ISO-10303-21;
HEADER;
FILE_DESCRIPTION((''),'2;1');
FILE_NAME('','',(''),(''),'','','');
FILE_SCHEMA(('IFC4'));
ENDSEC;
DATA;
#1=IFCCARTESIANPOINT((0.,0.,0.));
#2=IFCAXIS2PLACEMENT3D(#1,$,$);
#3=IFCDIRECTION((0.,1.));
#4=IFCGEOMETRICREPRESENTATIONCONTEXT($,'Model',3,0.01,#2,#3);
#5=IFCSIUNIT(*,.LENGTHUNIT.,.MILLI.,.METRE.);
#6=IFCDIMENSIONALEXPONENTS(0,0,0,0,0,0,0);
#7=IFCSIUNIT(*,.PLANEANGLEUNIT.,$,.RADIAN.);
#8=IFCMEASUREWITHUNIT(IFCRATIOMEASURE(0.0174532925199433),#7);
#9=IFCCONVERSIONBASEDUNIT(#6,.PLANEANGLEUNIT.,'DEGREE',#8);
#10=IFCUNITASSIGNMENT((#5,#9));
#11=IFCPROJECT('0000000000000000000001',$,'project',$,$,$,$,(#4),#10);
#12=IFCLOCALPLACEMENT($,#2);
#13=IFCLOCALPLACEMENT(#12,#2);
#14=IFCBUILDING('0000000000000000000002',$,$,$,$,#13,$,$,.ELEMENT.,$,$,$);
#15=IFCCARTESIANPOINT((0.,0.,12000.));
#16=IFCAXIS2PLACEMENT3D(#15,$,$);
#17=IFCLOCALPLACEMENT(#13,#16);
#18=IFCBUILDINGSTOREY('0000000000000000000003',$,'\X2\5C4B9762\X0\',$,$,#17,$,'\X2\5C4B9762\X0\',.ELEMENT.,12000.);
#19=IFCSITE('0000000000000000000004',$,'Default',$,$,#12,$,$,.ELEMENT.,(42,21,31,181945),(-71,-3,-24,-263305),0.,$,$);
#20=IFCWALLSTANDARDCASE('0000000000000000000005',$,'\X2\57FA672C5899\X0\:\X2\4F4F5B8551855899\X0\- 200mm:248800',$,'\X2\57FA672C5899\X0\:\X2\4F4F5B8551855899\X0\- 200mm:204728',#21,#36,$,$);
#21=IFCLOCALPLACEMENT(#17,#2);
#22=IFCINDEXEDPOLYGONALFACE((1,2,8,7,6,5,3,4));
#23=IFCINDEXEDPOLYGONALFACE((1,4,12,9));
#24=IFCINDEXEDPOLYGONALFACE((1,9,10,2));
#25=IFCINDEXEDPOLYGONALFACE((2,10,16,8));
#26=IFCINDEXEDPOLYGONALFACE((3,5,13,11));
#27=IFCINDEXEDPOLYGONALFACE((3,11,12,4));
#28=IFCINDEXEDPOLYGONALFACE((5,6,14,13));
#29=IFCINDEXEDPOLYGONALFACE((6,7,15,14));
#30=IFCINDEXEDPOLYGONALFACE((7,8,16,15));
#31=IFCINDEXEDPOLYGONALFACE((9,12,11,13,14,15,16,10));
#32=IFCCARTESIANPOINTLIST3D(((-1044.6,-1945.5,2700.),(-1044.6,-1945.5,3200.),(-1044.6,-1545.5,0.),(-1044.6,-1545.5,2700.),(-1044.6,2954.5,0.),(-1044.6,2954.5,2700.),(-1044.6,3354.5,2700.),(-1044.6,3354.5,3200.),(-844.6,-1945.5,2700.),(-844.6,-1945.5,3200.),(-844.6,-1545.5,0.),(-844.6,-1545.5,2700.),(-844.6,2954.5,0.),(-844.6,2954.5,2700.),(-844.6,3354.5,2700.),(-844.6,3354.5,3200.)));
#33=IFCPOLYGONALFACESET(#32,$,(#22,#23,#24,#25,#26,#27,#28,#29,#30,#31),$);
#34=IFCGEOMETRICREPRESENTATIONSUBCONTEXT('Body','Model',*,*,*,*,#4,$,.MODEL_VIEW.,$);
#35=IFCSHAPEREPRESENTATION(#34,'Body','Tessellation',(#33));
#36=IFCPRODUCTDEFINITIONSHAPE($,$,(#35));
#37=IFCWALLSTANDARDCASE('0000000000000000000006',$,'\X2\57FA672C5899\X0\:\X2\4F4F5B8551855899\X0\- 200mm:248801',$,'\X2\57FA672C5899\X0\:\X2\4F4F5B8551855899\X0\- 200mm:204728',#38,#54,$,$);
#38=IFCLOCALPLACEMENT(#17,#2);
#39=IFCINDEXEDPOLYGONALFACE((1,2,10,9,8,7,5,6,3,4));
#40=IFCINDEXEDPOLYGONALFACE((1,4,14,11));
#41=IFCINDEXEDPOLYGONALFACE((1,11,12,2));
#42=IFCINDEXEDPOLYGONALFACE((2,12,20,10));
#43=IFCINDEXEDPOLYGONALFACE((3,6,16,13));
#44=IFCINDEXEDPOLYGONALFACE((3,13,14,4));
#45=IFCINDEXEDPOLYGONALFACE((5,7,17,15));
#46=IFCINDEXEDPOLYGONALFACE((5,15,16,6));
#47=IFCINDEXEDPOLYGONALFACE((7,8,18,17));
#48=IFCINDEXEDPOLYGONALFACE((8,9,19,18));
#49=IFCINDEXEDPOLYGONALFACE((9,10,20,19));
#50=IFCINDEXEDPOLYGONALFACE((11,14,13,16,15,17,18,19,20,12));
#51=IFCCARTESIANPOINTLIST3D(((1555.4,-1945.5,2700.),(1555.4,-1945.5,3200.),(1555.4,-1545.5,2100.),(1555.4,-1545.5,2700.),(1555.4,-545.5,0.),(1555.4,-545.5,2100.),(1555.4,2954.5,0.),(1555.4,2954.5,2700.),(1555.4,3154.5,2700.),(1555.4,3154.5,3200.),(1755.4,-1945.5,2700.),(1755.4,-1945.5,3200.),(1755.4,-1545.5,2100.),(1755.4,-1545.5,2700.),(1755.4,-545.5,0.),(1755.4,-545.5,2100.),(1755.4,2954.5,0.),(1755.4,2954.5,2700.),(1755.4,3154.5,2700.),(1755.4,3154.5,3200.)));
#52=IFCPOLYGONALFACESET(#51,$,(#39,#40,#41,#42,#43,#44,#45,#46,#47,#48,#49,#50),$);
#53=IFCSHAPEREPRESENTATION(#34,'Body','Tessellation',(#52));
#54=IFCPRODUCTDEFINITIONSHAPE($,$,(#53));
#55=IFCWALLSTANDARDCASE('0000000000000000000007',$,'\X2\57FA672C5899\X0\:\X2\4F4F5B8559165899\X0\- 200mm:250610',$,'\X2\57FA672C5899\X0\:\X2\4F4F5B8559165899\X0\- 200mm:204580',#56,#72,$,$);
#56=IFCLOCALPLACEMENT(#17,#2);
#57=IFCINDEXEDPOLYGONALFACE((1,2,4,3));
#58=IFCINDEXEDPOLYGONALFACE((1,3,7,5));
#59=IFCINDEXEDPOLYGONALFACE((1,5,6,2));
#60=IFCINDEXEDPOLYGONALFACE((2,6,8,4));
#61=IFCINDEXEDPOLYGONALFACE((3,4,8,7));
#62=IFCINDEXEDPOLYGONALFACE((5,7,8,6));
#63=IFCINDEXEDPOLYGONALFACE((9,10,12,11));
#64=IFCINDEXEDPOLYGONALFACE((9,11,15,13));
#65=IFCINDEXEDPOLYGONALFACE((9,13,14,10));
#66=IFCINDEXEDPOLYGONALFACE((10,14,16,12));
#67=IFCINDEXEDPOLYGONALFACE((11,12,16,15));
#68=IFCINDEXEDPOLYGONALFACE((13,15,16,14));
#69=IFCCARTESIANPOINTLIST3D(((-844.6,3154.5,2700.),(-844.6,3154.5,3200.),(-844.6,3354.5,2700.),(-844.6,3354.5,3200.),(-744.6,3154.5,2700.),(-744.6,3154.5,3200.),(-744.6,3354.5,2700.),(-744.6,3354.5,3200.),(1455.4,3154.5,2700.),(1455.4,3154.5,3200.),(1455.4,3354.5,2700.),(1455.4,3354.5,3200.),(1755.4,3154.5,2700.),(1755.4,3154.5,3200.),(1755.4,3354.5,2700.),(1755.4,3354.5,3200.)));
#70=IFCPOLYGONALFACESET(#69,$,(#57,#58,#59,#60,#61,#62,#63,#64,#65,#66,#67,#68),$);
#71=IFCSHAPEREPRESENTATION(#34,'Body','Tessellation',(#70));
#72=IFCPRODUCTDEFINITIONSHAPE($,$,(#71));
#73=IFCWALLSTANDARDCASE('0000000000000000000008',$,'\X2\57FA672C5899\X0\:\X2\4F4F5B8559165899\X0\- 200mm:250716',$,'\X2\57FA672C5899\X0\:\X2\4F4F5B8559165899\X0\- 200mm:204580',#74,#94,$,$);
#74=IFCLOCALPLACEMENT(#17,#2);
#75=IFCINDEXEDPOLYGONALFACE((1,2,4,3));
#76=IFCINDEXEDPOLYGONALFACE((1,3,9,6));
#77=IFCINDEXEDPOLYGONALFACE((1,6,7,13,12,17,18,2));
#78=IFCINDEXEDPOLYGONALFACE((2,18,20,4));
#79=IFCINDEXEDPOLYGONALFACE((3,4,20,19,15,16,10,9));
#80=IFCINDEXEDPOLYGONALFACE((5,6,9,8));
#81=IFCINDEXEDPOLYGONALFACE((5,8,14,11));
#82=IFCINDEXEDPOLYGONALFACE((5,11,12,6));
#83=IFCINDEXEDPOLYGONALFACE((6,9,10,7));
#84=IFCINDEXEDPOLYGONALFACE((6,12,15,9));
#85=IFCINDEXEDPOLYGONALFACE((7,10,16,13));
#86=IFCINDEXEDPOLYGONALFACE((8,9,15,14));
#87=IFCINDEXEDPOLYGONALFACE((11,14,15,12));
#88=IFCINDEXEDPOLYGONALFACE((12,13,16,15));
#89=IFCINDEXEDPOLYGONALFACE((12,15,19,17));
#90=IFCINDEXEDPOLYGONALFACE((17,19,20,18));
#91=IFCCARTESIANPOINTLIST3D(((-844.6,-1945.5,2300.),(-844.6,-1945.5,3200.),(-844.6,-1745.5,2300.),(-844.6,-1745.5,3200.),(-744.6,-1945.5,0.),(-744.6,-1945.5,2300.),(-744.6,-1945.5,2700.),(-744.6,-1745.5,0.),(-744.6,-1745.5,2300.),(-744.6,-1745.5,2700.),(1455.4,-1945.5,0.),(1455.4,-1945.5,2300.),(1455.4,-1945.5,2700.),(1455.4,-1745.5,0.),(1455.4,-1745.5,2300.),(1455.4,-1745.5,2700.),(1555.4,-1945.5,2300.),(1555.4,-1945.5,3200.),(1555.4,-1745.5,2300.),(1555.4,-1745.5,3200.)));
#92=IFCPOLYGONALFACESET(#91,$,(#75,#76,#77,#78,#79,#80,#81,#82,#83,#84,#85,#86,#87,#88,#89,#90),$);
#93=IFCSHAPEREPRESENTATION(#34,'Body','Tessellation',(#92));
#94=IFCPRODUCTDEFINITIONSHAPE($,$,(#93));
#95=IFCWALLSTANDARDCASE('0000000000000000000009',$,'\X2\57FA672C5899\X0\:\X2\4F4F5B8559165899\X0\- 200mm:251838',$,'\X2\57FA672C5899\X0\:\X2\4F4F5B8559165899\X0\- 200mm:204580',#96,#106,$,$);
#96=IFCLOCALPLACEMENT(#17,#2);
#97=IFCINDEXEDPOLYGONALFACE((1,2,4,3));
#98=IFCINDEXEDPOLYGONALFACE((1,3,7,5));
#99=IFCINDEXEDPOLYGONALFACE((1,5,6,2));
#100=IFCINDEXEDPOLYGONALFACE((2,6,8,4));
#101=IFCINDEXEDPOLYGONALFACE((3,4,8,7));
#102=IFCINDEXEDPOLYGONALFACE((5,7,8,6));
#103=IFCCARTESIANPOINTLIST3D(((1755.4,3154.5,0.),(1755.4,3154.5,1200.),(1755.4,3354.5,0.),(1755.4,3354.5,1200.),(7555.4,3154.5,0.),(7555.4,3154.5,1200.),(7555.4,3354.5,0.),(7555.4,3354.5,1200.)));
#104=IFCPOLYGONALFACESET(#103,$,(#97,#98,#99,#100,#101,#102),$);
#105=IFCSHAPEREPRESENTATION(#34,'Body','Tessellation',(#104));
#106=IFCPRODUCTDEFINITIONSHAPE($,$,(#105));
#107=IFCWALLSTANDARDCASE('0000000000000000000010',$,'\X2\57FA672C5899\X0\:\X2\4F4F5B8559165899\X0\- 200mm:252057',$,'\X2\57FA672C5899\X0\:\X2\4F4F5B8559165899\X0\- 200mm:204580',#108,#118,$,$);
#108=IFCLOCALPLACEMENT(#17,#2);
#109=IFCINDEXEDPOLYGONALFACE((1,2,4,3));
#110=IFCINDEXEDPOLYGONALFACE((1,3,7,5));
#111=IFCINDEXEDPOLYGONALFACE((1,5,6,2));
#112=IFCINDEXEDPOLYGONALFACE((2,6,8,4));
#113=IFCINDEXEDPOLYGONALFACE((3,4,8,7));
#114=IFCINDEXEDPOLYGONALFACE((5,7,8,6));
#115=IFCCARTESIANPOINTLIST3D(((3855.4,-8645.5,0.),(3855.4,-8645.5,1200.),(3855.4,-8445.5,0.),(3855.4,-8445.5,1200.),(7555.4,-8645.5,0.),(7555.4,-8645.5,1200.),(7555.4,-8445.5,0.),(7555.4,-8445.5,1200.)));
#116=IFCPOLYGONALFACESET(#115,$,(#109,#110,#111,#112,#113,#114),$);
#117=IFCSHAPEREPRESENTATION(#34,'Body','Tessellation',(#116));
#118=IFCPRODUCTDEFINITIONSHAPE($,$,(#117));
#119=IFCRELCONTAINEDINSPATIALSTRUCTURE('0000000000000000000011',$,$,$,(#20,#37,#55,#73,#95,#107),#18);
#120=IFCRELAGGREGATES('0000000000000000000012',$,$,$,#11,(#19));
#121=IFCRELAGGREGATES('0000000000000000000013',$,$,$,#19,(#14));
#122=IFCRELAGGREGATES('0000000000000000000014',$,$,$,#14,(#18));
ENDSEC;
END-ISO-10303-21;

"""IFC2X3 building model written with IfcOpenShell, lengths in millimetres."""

from ifc_helpers import new_model, entity, si_unit, converted_unit, direction, frame, frame_2d, origin, origin_2d_with_axis, place, context, subcontext, project, spatial, polyline, rectangle, extrude, clip, bounded_halfspace, element, save


model = new_model("IFC2X3")

# Units and contexts
model_context = context("Model", 3, precision=0.01, world=origin(), true_north=direction((0.0, 1.0)))
body_context = subcontext(model_context, "Body", "Model", "MODEL_VIEW")
ifc_project = project(units=[si_unit("LENGTHUNIT", "METRE", prefix="MILLI"), converted_unit("PLANEANGLEUNIT", "DEGREE", entity("IfcRatioMeasure", 0.0174532925199433), si_unit("PLANEANGLEUNIT", "RADIAN"), dimensions=[0, 0, 0, 0, 0, 0, 0])], contexts=[model_context])

# Site, building, storey
site_placement = place(None, origin())
site = spatial("IfcSite", under=ifc_project, at=site_placement, Name="Default", CompositionType="ELEMENT", RefLatitude=(42, 21, 31, 181945), RefLongitude=(-71, -3, -24, -263305), RefElevation=0.0)
building_placement = place(site_placement, origin())
building = spatial("IfcBuilding", under=site, at=building_placement, CompositionType="ELEMENT")
storey_placement = place(building_placement, frame((0.0, 0.0, 12000.0)))
storey = spatial("IfcBuildingStorey", under=building, at=storey_placement, Name="屋面", LongName="屋面", CompositionType="ELEMENT", Elevation=12000.0)

# Wall
wall_1_placement = place(storey_placement, frame((-944.6, 3354.5, 0.0), z_axis=(0.0, 0.0, 1.0), x_axis=(0.0, -1.0, 0.0)))
element("IfcWallStandardCase", 1, at=wall_1_placement, inside=storey, Name="基本墙:住宅内墙- 200mm:248800", ObjectType="基本墙:住宅内墙- 200mm:204728", context=body_context, shape_type="Clipping", body=[
    clip(clip(clip(clip(extrude(rectangle(XDim=5300.0, YDim=200.0, at=frame_2d((2650.0, 0.0), x_axis=(-1.0, 0.0))), origin(), (0.0, 0.0, 1.0), 3200.0), bounded_halfspace(frame((400.0, -100.0, 2700.0), z_axis=(1.0, 0.0, 0.0), x_axis=(0.0, 0.0, -1.0)), True, frame((400.0, -100.0, 2700.0), z_axis=(1.0, 0.0, 0.0), x_axis=(0.0, 0.0, -1.0)), polyline([(0.0, 0.0), (2700.0, 0.0), (2700.0, 200.0), (0.0, 200.0), (0.0, 0.0)]))), bounded_halfspace(frame((400.0, 100.0, 2700.0), z_axis=(0.0, 0.0, 1.0), x_axis=(0.0, -1.0, 0.0)), True, frame((400.0, 100.0, 2700.0), z_axis=(0.0, 0.0, 1.0), x_axis=(0.0, -1.0, 0.0)), polyline([(0.0, 0.0), (0.0, -200.0), (0.0, -400.0), (200.0, -400.0), (200.0, 0.0), (0.0, 0.0)]))), bounded_halfspace(frame((4900.0, 100.0, 2700.0), z_axis=(1.0, 0.0, 0.0), x_axis=(0.0, 0.0, -1.0)), False, frame((4900.0, 100.0, 2700.0), z_axis=(1.0, 0.0, 0.0), x_axis=(0.0, 0.0, -1.0)), polyline([(0.0, 0.0), (0.0, -200.0), (2700.0, -200.0), (2700.0, 0.0), (0.0, 0.0)]))), bounded_halfspace(frame((4900.0, -100.0, 2700.0), z_axis=(0.0, 0.0, -1.0), x_axis=(0.0, 1.0, 0.0)), False, frame((4900.0, -100.0, 2700.0), z_axis=(0.0, 0.0, -1.0), x_axis=(0.0, 1.0, 0.0)), polyline([(0.0, 0.0), (200.0, 0.0), (200.0, 200.0), (200.0, 400.0), (0.0, 400.0), (0.0, 0.0)]))),
])

# Walls, openings
wall_2_placement = place(storey_placement, frame((1655.4, -1945.5, 0.0), z_axis=(0.0, 0.0, 1.0), x_axis=(0.0, 1.0, 0.0)))
wall_2 = element("IfcWallStandardCase", 2, at=wall_2_placement, inside=storey, Name="基本墙:住宅内墙- 200mm:248801", ObjectType="基本墙:住宅内墙- 200mm:204728", context=body_context, shape_type="Clipping", body=[
    clip(clip(clip(clip(extrude(rectangle(XDim=5100.0, YDim=200.0, at=frame_2d((2550.0, 0.0), x_axis=(-1.0, 0.0))), origin(), (0.0, 0.0, 1.0), 3200.0), bounded_halfspace(frame((400.0, -100.0, 2700.0), z_axis=(-1.0, 0.0, 0.0), x_axis=(0.0, 0.0, -1.0)), False, frame((400.0, -100.0, 2700.0), z_axis=(-1.0, 0.0, 0.0), x_axis=(0.0, 0.0, -1.0)), polyline([(0.0, 0.0), (0.0, -200.0), (600.0, -200.0), (600.0, 0.0), (0.0, 0.0)]))), bounded_halfspace(frame((400.0, 100.0, 2700.0), z_axis=(0.0, 0.0, -1.0), x_axis=(0.0, -1.0, 0.0)), False, frame((400.0, 100.0, 2700.0), z_axis=(0.0, 0.0, -1.0), x_axis=(0.0, -1.0, 0.0)), polyline([(0.0, 0.0), (200.0, 0.0), (200.0, 400.0), (0.0, 400.0), (0.0, 200.0), (0.0, 0.0)]))), bounded_halfspace(frame((4900.0, 100.0, 2700.0), z_axis=(1.0, 0.0, 0.0), x_axis=(0.0, 0.0, -1.0)), False, frame((4900.0, 100.0, 2700.0), z_axis=(1.0, 0.0, 0.0), x_axis=(0.0, 0.0, -1.0)), polyline([(0.0, 0.0), (0.0, -200.0), (2700.0, -200.0), (2700.0, 0.0), (0.0, 0.0)]))), bounded_halfspace(frame((4900.0, -100.0, 2700.0), z_axis=(0.0, 0.0, -1.0), x_axis=(0.0, -1.0, 0.0)), False, frame((4900.0, -100.0, 2700.0), z_axis=(0.0, 0.0, -1.0), x_axis=(0.0, -1.0, 0.0)), polyline([(0.0, 0.0), (-200.0, 0.0), (-200.0, -200.0), (0.0, -200.0), (0.0, 0.0)]))),
])
opening_1_placement = place(wall_2_placement, frame((400.0, -100.0, 0.0)))
element("IfcOpeningElement", 3, at=opening_1_placement, cuts=wall_2, ObjectType="Opening", context=body_context, shape_type="SweptSolid", body=[
    extrude(rectangle(XDim=2100.0, YDim=1000.0, at=frame_2d((1050.0, 500.0), x_axis=(1.0, 0.0))), frame((0.0, 0.0, 0.0), z_axis=(0.0, 1.0, 0.0), x_axis=(0.0, 0.0, 1.0)), (0.0, 0.0, 1.0), 200.0),
])
wall_3_placement = place(storey_placement, frame((-844.6, 3254.5, 0.0)))
wall_3 = element("IfcWallStandardCase", 4, at=wall_3_placement, inside=storey, Name="基本墙:住宅外墙- 200mm:250610", ObjectType="基本墙:住宅外墙- 200mm:204580", context=body_context, shape_type="Clipping", body=[
    clip(clip(clip(clip(extrude(rectangle(XDim=2600.0, YDim=200.0, at=frame_2d((1300.0, 0.0), x_axis=(-1.0, 0.0))), origin(), (0.0, 0.0, 1.0), 3200.0), bounded_halfspace(frame((2300.0, -100.0, 0.0), z_axis=(1.0, 0.0, 0.0), x_axis=(0.0, 0.0, -1.0)), False, frame((2300.0, -100.0, 0.0), z_axis=(1.0, 0.0, 0.0), x_axis=(0.0, 0.0, -1.0)), polyline([(0.0, 0.0), (0.0, 200.0), (-2300.0, 200.0), (-2300.0, 0.0), (0.0, 0.0)]))), bounded_halfspace(frame((2600.0, 100.0, 2700.0), z_axis=(0.0, 0.0, -1.0), x_axis=(1.0, 0.0, 0.0)), False, frame((2600.0, 100.0, 2700.0), z_axis=(0.0, 0.0, -1.0), x_axis=(1.0, 0.0, 0.0)), polyline([(0.0, 0.0), (0.0, 200.0), (-200.0, 200.0), (-300.0, 200.0), (-2500.0, 200.0), (-2600.0, 200.0), (-2600.0, 0.0), (-2500.0, 0.0), (-300.0, 0.0), (0.0, 0.0)]))), bounded_halfspace(frame((2300.0, -100.0, 2300.0), z_axis=(0.0, 0.0, -1.0), x_axis=(-1.0, 0.0, 0.0)), True, frame((2300.0, -100.0, 2300.0), z_axis=(0.0, 0.0, -1.0), x_axis=(-1.0, 0.0, 0.0)), polyline([(0.0, 0.0), (2200.0, 0.0), (2200.0, 200.0), (0.0, 200.0), (0.0, 0.0)]))), bounded_halfspace(frame((100.0, -100.0, 0.0), z_axis=(1.0, 0.0, 0.0), x_axis=(0.0, 0.0, -1.0)), True, frame((100.0, -100.0, 0.0), z_axis=(1.0, 0.0, 0.0), x_axis=(0.0, 0.0, -1.0)), polyline([(0.0, 0.0), (0.0, 200.0), (-2300.0, 200.0), (-2300.0, 0.0), (0.0, 0.0)]))),
])
opening_2_placement = place(wall_3_placement, frame((429.8, -100.0, 0.0)))
element("IfcOpeningElement", 5, at=opening_2_placement, cuts=wall_3, ObjectType="Opening", context=body_context, shape_type="SweptSolid", body=[
    extrude(rectangle(XDim=500.0, YDim=1500.0, at=frame_2d((250.0, 750.0), x_axis=(1.0, 0.0))), frame((0.0, 0.0, 0.0), z_axis=(0.0, 1.0, 0.0), x_axis=(0.0, 0.0, 1.0)), (0.0, 0.0, 1.0), 200.0),
])
wall_4_placement = place(storey_placement, frame((-844.6, -1845.5, 0.0)))
wall_4 = element("IfcWallStandardCase", 6, at=wall_4_placement, inside=storey, Name="基本墙:住宅外墙- 200mm:250716", ObjectType="基本墙:住宅外墙- 200mm:204580", context=body_context, shape_type="Clipping", body=[
    clip(clip(extrude(rectangle(XDim=2400.0, YDim=200.0, at=frame_2d((1200.0, 0.0), x_axis=(-1.0, 0.0))), origin(), (0.0, 0.0, 1.0), 3200.0), bounded_halfspace(frame((2300.0, -100.0, 2300.0), z_axis=(1.0, 0.0, 0.0), x_axis=(0.0, 0.0, -1.0)), False, frame((2300.0, -100.0, 2300.0), z_axis=(1.0, 0.0, 0.0), x_axis=(0.0, 0.0, -1.0)), polyline([(0.0, 0.0), (2300.0, 0.0), (2300.0, 200.0), (0.0, 200.0), (0.0, 0.0)]))), bounded_halfspace(frame((100.0, -100.0, 0.0), z_axis=(-1.0, 0.0, 0.0), x_axis=(0.0, 0.0, -1.0)), False, frame((100.0, -100.0, 0.0), z_axis=(-1.0, 0.0, 0.0), x_axis=(0.0, 0.0, -1.0)), polyline([(0.0, 0.0), (-2300.0, 0.0), (-2300.0, -200.0), (0.0, -200.0), (0.0, 0.0)]))),
])
opening_3_placement = place(storey_placement, frame((-844.6, -1845.5, 0.0)))
element("IfcOpeningElement", 7, at=opening_3_placement, cuts=wall_4, ObjectType="Opening", context=body_context, shape_type="SweptSolid", body=[
    extrude(rectangle(XDim=200.0, YDim=2200.0, at=origin_2d_with_axis()), frame((1200.0, 0.0, 2300.0), z_axis=(0.0, 0.0, 1.0), x_axis=(0.0, 1.0, 0.0)), (0.0, 0.0, 1.0), 400.0),
])

# Walls
wall_5_placement = place(storey_placement, frame((1755.4, 3254.5, 0.0)))
element("IfcWallStandardCase", 8, at=wall_5_placement, inside=storey, Name="基本墙:住宅外墙- 200mm:251838", ObjectType="基本墙:住宅外墙- 200mm:204580", context=body_context, shape_type="SweptSolid", body=[
    extrude(rectangle(XDim=5800.0, YDim=200.0, at=frame_2d((2900.0, 0.0), x_axis=(-1.0, 0.0))), origin(), (0.0, 0.0, 1.0), 1200.0),
])
wall_6_placement = place(storey_placement, frame((7555.4, -8545.5, 0.0), z_axis=(0.0, 0.0, 1.0), x_axis=(-1.0, 0.0, 0.0)))
element("IfcWallStandardCase", 9, at=wall_6_placement, inside=storey, Name="基本墙:住宅外墙- 200mm:252057", ObjectType="基本墙:住宅外墙- 200mm:204580", context=body_context, shape_type="SweptSolid", body=[
    extrude(rectangle(XDim=3700.0, YDim=200.0, at=frame_2d((1850.0, 0.0), x_axis=(-1.0, 0.0))), origin(), (0.0, 0.0, 1.0), 1200.0),
])

save(model, "model.ifc")
